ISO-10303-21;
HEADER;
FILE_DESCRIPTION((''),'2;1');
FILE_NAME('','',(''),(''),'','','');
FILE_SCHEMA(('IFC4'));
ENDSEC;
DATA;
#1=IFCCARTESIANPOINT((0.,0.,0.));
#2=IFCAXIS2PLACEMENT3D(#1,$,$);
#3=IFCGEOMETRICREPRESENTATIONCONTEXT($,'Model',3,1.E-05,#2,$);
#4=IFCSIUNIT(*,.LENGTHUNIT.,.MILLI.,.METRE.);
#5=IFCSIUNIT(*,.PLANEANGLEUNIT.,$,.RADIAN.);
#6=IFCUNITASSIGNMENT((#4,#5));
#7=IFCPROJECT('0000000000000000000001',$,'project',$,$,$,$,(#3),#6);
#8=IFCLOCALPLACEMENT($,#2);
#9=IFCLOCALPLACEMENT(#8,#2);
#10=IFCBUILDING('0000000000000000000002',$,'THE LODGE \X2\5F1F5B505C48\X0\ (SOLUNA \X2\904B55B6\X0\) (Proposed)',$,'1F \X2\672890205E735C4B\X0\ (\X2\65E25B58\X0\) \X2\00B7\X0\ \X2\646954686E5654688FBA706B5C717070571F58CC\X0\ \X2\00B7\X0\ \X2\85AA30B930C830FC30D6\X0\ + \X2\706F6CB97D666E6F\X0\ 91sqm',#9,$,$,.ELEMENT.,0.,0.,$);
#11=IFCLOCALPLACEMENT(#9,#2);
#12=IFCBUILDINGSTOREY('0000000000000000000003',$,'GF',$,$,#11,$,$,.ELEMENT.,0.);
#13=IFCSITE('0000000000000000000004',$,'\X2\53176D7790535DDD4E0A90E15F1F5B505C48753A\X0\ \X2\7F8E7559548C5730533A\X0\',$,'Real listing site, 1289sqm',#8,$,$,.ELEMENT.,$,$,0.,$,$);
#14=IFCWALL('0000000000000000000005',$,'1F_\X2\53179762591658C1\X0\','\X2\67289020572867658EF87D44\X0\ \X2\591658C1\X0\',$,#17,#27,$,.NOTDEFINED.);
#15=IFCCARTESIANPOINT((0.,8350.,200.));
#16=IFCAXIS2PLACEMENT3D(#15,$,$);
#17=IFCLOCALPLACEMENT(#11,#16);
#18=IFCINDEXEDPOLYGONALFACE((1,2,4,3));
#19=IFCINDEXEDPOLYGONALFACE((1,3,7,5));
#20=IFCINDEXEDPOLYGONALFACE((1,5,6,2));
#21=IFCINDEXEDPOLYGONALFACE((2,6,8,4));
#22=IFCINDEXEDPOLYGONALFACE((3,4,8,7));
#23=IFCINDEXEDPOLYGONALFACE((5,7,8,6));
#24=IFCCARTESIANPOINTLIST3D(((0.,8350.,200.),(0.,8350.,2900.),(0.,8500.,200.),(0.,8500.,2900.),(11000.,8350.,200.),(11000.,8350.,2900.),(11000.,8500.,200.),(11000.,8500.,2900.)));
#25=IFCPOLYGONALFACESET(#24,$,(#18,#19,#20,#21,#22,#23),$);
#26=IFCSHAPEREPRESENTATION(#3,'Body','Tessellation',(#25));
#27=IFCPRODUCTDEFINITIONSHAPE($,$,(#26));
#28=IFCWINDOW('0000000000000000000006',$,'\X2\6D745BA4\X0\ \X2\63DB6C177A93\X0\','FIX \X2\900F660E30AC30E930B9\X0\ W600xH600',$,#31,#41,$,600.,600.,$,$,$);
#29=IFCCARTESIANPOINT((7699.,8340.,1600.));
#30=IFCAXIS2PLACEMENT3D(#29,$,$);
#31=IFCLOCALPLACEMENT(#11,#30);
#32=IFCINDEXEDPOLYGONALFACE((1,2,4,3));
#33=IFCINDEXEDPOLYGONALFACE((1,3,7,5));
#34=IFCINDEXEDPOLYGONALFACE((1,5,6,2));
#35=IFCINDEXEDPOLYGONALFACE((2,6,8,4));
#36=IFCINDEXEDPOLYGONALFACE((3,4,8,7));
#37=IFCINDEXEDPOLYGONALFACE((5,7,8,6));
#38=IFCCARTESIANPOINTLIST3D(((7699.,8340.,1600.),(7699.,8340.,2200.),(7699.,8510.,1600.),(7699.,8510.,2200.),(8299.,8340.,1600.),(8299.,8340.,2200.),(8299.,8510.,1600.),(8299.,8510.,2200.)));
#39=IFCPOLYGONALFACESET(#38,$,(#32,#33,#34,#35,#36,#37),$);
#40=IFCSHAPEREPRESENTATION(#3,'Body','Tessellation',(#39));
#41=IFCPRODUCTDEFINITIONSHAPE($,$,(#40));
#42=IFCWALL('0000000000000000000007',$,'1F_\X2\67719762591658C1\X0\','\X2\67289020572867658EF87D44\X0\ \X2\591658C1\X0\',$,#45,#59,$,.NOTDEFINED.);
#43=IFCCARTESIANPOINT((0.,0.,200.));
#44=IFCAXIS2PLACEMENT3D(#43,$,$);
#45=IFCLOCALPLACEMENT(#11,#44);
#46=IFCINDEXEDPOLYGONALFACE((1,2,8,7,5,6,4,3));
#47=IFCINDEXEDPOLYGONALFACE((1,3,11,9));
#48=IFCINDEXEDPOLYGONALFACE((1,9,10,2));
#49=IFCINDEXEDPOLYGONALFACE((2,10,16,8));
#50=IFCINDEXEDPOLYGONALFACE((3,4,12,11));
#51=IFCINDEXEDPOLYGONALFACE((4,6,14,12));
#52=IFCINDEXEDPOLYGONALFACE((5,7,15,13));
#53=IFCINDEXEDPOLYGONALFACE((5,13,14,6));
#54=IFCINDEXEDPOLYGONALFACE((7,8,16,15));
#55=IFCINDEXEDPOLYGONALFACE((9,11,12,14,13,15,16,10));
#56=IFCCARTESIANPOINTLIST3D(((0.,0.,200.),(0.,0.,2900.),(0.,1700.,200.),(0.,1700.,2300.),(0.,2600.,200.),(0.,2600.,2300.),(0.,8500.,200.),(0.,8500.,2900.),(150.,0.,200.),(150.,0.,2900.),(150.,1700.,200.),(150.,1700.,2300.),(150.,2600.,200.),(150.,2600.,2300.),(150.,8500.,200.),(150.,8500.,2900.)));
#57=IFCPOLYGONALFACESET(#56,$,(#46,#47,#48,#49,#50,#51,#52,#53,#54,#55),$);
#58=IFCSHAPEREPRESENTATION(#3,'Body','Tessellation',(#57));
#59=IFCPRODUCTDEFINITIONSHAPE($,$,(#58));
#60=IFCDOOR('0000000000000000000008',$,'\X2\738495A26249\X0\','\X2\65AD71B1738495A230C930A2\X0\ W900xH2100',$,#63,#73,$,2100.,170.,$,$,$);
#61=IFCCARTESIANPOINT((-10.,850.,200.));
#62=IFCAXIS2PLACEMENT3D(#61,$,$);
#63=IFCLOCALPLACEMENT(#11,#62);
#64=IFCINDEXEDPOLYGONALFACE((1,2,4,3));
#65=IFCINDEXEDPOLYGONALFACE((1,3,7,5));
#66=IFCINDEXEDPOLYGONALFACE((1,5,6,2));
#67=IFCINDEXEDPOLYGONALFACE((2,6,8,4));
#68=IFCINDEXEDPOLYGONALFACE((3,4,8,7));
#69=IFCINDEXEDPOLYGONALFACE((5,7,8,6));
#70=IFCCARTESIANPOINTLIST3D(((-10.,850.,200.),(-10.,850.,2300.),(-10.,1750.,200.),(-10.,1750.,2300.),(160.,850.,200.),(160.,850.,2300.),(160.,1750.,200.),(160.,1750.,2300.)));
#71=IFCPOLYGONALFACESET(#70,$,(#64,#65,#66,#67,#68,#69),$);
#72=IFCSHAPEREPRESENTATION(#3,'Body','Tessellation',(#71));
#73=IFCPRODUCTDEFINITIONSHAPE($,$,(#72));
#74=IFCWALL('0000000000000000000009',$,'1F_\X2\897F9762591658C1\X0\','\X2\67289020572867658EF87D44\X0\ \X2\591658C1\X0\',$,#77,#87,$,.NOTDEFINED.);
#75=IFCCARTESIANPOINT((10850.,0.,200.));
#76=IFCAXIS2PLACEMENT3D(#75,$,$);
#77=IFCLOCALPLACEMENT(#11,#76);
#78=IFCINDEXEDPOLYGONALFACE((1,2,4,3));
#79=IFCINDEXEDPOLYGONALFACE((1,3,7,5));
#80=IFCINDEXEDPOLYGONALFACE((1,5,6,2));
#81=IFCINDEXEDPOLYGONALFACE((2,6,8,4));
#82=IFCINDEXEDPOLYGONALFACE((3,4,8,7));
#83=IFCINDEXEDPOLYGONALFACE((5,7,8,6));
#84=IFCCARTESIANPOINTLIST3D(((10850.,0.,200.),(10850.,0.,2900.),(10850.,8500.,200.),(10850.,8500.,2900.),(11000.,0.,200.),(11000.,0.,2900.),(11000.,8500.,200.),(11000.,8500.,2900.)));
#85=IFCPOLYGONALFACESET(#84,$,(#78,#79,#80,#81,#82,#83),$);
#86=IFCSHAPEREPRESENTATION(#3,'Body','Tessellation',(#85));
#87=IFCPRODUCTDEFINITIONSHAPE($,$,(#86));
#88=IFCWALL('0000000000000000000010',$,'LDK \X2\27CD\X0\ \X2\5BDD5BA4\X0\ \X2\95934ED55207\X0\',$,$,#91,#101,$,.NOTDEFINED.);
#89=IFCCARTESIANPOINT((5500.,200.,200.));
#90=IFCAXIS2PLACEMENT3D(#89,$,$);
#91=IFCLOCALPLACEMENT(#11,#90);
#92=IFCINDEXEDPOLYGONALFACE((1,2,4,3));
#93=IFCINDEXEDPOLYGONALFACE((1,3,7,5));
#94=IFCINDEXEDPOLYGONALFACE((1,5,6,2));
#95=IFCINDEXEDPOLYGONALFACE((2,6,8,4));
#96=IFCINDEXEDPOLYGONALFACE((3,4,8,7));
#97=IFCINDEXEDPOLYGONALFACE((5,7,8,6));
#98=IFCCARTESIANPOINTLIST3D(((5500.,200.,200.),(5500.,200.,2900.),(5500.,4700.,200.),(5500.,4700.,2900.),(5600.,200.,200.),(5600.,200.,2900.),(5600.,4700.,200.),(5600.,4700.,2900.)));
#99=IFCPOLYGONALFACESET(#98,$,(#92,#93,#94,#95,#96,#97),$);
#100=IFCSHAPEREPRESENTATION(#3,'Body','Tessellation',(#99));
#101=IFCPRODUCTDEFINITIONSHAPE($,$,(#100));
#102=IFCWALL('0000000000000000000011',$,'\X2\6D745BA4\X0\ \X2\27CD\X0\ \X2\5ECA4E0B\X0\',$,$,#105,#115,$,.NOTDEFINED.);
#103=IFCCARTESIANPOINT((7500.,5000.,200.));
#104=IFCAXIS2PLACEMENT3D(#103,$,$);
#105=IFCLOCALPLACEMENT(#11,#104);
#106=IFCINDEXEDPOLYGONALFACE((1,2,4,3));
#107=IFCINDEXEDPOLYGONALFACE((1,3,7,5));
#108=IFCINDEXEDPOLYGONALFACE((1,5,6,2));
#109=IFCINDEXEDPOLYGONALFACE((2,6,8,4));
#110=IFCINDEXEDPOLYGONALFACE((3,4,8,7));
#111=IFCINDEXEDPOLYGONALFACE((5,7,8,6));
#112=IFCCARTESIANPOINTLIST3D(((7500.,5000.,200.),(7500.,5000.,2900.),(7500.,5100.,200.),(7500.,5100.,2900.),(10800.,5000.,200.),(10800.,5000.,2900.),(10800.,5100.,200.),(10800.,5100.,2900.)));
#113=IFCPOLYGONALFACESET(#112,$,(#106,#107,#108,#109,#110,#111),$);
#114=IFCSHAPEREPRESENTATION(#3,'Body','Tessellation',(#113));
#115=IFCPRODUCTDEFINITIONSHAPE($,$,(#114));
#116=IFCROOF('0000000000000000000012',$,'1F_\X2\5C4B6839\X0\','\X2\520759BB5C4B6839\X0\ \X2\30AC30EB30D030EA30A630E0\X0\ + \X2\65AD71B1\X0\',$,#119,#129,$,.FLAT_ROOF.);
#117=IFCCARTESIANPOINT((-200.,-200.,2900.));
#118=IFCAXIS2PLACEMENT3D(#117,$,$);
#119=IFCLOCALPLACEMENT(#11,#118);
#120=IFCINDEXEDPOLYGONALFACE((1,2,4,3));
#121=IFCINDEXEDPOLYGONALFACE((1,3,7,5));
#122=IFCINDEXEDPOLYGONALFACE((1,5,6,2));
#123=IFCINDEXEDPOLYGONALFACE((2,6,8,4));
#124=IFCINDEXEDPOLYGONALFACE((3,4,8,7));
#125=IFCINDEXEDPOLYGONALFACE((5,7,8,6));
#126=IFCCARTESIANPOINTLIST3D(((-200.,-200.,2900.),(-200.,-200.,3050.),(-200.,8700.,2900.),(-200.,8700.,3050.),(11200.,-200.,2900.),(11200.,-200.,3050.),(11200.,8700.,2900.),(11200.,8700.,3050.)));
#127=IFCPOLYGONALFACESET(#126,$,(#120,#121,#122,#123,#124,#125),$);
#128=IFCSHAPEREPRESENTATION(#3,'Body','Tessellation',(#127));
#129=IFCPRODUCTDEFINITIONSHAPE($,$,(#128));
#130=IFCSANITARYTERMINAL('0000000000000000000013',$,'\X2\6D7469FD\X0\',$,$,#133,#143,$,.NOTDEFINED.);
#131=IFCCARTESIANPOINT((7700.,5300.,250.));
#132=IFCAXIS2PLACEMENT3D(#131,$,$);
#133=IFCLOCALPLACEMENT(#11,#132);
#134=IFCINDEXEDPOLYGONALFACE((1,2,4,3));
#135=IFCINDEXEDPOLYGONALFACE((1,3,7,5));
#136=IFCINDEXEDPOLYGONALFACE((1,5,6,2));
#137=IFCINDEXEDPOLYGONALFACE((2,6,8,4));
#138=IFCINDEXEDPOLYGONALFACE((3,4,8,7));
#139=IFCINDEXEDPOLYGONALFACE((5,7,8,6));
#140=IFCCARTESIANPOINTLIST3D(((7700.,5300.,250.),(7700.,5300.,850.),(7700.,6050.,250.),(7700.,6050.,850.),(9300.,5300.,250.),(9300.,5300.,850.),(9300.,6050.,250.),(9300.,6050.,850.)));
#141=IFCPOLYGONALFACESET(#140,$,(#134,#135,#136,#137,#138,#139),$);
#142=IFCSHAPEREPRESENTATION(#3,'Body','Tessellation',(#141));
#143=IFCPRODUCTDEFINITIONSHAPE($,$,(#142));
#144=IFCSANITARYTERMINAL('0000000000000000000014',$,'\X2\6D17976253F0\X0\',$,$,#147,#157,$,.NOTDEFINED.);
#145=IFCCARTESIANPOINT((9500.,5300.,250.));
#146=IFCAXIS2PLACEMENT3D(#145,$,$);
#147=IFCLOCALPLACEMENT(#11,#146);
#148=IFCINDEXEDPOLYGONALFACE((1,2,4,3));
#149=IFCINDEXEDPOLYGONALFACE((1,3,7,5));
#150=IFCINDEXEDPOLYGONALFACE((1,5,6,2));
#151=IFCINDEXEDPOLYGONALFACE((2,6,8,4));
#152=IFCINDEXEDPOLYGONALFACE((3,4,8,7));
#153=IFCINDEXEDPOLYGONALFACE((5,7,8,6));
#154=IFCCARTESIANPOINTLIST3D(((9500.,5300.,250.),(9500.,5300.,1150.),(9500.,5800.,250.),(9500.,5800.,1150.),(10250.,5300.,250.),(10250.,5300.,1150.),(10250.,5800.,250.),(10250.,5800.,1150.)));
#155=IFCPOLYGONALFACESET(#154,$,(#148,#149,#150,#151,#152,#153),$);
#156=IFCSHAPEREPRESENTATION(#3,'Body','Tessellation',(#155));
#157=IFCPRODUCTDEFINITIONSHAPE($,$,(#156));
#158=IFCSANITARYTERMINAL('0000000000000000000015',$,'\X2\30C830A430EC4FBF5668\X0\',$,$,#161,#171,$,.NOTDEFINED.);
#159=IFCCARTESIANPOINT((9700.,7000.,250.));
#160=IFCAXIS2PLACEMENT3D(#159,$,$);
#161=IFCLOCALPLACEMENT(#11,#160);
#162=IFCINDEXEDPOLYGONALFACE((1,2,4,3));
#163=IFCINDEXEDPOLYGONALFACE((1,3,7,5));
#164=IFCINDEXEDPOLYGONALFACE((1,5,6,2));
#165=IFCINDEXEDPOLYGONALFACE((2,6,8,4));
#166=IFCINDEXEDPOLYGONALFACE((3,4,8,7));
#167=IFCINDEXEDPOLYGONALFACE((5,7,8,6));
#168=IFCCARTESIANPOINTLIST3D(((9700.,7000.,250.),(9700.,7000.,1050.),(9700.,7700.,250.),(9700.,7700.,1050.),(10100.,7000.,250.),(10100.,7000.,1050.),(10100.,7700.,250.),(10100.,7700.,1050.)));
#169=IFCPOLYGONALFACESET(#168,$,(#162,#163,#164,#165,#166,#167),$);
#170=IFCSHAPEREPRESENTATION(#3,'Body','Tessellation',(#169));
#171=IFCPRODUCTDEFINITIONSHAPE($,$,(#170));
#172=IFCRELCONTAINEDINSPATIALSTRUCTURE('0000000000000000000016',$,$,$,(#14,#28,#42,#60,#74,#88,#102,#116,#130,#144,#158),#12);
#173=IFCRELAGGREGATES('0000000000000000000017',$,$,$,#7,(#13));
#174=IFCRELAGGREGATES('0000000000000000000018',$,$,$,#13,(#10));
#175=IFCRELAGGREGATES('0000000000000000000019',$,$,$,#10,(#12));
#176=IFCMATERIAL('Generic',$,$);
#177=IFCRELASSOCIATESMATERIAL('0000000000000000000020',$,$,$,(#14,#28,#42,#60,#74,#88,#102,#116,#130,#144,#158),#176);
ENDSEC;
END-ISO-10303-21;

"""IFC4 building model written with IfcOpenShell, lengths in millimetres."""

from ifc_helpers import new_model, si_unit, frame, frame_2d, origin, place, context, project, spatial, rectangle, extrude, material, element, fill, save


model = new_model("IFC4")

# Units and contexts
model_context = context("Model", 3, precision=1e-05, world=origin())
ifc_project = project(units=[si_unit("LENGTHUNIT", "METRE", prefix="MILLI"), si_unit("PLANEANGLEUNIT", "RADIAN")], contexts=[model_context])

# Site, building, storey
site_placement = place(None, origin())
site = spatial("IfcSite", under=ifc_project, at=site_placement, Name="北海道川上郡弟子屈町 美留和地区", ObjectType="Real listing site, 1289sqm", CompositionType="ELEMENT", RefElevation=0.0)
building_placement = place(site_placement, origin())
building = spatial("IfcBuilding", under=site, at=building_placement, Name="THE LODGE 弟子屈 (SOLUNA 運営) (Proposed)", ObjectType="1F 木造平屋 (既存) · 摩周湖周辺火山灰土壌 · 薪ストーブ + 灯油給湯 91sqm", CompositionType="ELEMENT", ElevationOfRefHeight=0.0, ElevationOfTerrain=0.0)
storey_placement = place(building_placement, origin())
storey = spatial("IfcBuildingStorey", under=building, at=storey_placement, Name="GF", CompositionType="ELEMENT", Elevation=0.0)

# Wall, opening, window
ifc_material_1 = material(Name="Generic")
wall_1_placement = place(storey_placement, frame((0.0, 8350.0, 200.0)))
wall_1 = element("IfcWall", 1, at=wall_1_placement, inside=storey, material=ifc_material_1, Name="1F_北面外壁", Description="木造在来軸組 外壁", PredefinedType="NOTDEFINED", context=model_context, shape_type="SweptSolid", body=[
    extrude(rectangle(XDim=11000.0, YDim=150.0, at=frame_2d((5500.0, 75.0))), frame((0.0, 8350.0, 200.0)), (0.0, 0.0, 1.0), 2700.0),
])
opening_1_placement = place(storey_placement, frame((7699.0, 8340.0, 1600.0)))
opening_1 = element("IfcOpeningElement", 2, at=opening_1_placement, cuts=wall_1, PredefinedType="NOTDEFINED", context=model_context, shape_type="SweptSolid", body=[
    extrude(rectangle(XDim=600.0, YDim=170.0, at=frame_2d((300.0, 85.0))), frame((7699.0, 8340.0, 1600.0)), (0.0, 0.0, 1.0), 600.0),
])
window_1_placement = place(storey_placement, frame((7699.0, 8340.0, 1600.0)))
window_1 = element("IfcWindow", 3, at=window_1_placement, inside=storey, material=ifc_material_1, Name="浴室 換気窓", Description="FIX 透明ガラス W600xH600", OverallHeight=600.0, OverallWidth=600.0, context=model_context, shape_type="SweptSolid", body=[
    extrude(rectangle(XDim=600.0, YDim=170.0, at=frame_2d((300.0, 85.0))), frame((7699.0, 8340.0, 1600.0)), (0.0, 0.0, 1.0), 600.0),
])
fill(opening_1, window_1)

# Wall, opening, door
wall_2_placement = place(storey_placement, frame((0.0, 0.0, 200.0)))
wall_2 = element("IfcWall", 4, at=wall_2_placement, inside=storey, material=ifc_material_1, Name="1F_東面外壁", Description="木造在来軸組 外壁", PredefinedType="NOTDEFINED", context=model_context, shape_type="SweptSolid", body=[
    extrude(rectangle(XDim=150.0, YDim=8500.0, at=frame_2d((75.0, 4250.0))), frame((0.0, 0.0, 200.0)), (0.0, 0.0, 1.0), 2700.0),
])
opening_2_placement = place(storey_placement, frame((-10.0, 850.0, 200.0)))
opening_2 = element("IfcOpeningElement", 5, at=opening_2_placement, cuts=wall_2, PredefinedType="NOTDEFINED", context=model_context, shape_type="SweptSolid", body=[
    extrude(rectangle(XDim=170.0, YDim=900.0, at=frame_2d((85.0, 450.0))), frame((-10.0, 850.0, 200.0)), (0.0, 0.0, 1.0), 2100.0),
])
door_placement = place(storey_placement, frame((-10.0, 850.0, 200.0)))
door = element("IfcDoor", 6, at=door_placement, inside=storey, material=ifc_material_1, Name="玄関扉", Description="断熱玄関ドア W900xH2100", OverallHeight=2100.0, OverallWidth=170.0, context=model_context, shape_type="SweptSolid", body=[
    extrude(rectangle(XDim=170.0, YDim=900.0, at=frame_2d((85.0, 450.0))), frame((-10.0, 850.0, 200.0)), (0.0, 0.0, 1.0), 2100.0),
])
fill(opening_2, door)

# Walls
wall_3_placement = place(storey_placement, frame((10850.0, 0.0, 200.0)))
element("IfcWall", 7, at=wall_3_placement, inside=storey, material=ifc_material_1, Name="1F_西面外壁", Description="木造在来軸組 外壁", PredefinedType="NOTDEFINED", context=model_context, shape_type="SweptSolid", body=[
    extrude(rectangle(XDim=150.0, YDim=8500.0, at=frame_2d((75.0, 4250.0))), frame((10850.0, 0.0, 200.0)), (0.0, 0.0, 1.0), 2700.0),
])
wall_4_placement = place(storey_placement, frame((5500.0, 200.0, 200.0)))
element("IfcWall", 8, at=wall_4_placement, inside=storey, material=ifc_material_1, Name="LDK ⟍ 寝室 間仕切", PredefinedType="NOTDEFINED", context=model_context, shape_type="SweptSolid", body=[
    extrude(rectangle(XDim=100.0, YDim=4500.0, at=frame_2d((50.0, 2250.0))), frame((5500.0, 200.0, 200.0)), (0.0, 0.0, 1.0), 2700.0),
])
wall_5_placement = place(storey_placement, frame((7500.0, 5000.0, 200.0)))
element("IfcWall", 9, at=wall_5_placement, inside=storey, material=ifc_material_1, Name="浴室 ⟍ 廊下", PredefinedType="NOTDEFINED", context=model_context, shape_type="SweptSolid", body=[
    extrude(rectangle(XDim=3300.0, YDim=100.0, at=frame_2d((1650.0, 50.0))), frame((7500.0, 5000.0, 200.0)), (0.0, 0.0, 1.0), 2700.0),
])

# Roof
roof_placement = place(storey_placement, frame((-200.0, -200.0, 2900.0)))
element("IfcRoof", 10, at=roof_placement, inside=storey, material=ifc_material_1, Name="1F_屋根", Description="切妻屋根 ガルバリウム + 断熱", PredefinedType="FLAT_ROOF", context=model_context, shape_type="SweptSolid", body=[
    extrude(rectangle(XDim=11400.0, YDim=8900.0, at=frame_2d((5700.0, 4450.0))), frame((-200.0, -200.0, 2900.0)), (0.0, 0.0, 1.0), 150.0),
])

# Sanitary terminals
sanitary_terminal_1_placement = place(storey_placement, frame((7700.0, 5300.0, 250.0)))
element("IfcSanitaryTerminal", 11, at=sanitary_terminal_1_placement, inside=storey, material=ifc_material_1, Name="浴槽", PredefinedType="NOTDEFINED", context=model_context, shape_type="SweptSolid", body=[
    extrude(rectangle(XDim=1600.0, YDim=750.0, at=frame_2d((800.0, 375.0))), frame((7700.0, 5300.0, 250.0)), (0.0, 0.0, 1.0), 600.0),
])
sanitary_terminal_2_placement = place(storey_placement, frame((9500.0, 5300.0, 250.0)))
element("IfcSanitaryTerminal", 12, at=sanitary_terminal_2_placement, inside=storey, material=ifc_material_1, Name="洗面台", PredefinedType="NOTDEFINED", context=model_context, shape_type="SweptSolid", body=[
    extrude(rectangle(XDim=750.0, YDim=500.0, at=frame_2d((375.0, 250.0))), frame((9500.0, 5300.0, 250.0)), (0.0, 0.0, 1.0), 900.0),
])
sanitary_terminal_3_placement = place(storey_placement, frame((9700.0, 7000.0, 250.0)))
element("IfcSanitaryTerminal", 13, at=sanitary_terminal_3_placement, inside=storey, material=ifc_material_1, Name="トイレ便器", PredefinedType="NOTDEFINED", context=model_context, shape_type="SweptSolid", body=[
    extrude(rectangle(XDim=400.0, YDim=700.0, at=frame_2d((200.0, 350.0))), frame((9700.0, 7000.0, 250.0)), (0.0, 0.0, 1.0), 800.0),
])

save(model, "model.ifc")
